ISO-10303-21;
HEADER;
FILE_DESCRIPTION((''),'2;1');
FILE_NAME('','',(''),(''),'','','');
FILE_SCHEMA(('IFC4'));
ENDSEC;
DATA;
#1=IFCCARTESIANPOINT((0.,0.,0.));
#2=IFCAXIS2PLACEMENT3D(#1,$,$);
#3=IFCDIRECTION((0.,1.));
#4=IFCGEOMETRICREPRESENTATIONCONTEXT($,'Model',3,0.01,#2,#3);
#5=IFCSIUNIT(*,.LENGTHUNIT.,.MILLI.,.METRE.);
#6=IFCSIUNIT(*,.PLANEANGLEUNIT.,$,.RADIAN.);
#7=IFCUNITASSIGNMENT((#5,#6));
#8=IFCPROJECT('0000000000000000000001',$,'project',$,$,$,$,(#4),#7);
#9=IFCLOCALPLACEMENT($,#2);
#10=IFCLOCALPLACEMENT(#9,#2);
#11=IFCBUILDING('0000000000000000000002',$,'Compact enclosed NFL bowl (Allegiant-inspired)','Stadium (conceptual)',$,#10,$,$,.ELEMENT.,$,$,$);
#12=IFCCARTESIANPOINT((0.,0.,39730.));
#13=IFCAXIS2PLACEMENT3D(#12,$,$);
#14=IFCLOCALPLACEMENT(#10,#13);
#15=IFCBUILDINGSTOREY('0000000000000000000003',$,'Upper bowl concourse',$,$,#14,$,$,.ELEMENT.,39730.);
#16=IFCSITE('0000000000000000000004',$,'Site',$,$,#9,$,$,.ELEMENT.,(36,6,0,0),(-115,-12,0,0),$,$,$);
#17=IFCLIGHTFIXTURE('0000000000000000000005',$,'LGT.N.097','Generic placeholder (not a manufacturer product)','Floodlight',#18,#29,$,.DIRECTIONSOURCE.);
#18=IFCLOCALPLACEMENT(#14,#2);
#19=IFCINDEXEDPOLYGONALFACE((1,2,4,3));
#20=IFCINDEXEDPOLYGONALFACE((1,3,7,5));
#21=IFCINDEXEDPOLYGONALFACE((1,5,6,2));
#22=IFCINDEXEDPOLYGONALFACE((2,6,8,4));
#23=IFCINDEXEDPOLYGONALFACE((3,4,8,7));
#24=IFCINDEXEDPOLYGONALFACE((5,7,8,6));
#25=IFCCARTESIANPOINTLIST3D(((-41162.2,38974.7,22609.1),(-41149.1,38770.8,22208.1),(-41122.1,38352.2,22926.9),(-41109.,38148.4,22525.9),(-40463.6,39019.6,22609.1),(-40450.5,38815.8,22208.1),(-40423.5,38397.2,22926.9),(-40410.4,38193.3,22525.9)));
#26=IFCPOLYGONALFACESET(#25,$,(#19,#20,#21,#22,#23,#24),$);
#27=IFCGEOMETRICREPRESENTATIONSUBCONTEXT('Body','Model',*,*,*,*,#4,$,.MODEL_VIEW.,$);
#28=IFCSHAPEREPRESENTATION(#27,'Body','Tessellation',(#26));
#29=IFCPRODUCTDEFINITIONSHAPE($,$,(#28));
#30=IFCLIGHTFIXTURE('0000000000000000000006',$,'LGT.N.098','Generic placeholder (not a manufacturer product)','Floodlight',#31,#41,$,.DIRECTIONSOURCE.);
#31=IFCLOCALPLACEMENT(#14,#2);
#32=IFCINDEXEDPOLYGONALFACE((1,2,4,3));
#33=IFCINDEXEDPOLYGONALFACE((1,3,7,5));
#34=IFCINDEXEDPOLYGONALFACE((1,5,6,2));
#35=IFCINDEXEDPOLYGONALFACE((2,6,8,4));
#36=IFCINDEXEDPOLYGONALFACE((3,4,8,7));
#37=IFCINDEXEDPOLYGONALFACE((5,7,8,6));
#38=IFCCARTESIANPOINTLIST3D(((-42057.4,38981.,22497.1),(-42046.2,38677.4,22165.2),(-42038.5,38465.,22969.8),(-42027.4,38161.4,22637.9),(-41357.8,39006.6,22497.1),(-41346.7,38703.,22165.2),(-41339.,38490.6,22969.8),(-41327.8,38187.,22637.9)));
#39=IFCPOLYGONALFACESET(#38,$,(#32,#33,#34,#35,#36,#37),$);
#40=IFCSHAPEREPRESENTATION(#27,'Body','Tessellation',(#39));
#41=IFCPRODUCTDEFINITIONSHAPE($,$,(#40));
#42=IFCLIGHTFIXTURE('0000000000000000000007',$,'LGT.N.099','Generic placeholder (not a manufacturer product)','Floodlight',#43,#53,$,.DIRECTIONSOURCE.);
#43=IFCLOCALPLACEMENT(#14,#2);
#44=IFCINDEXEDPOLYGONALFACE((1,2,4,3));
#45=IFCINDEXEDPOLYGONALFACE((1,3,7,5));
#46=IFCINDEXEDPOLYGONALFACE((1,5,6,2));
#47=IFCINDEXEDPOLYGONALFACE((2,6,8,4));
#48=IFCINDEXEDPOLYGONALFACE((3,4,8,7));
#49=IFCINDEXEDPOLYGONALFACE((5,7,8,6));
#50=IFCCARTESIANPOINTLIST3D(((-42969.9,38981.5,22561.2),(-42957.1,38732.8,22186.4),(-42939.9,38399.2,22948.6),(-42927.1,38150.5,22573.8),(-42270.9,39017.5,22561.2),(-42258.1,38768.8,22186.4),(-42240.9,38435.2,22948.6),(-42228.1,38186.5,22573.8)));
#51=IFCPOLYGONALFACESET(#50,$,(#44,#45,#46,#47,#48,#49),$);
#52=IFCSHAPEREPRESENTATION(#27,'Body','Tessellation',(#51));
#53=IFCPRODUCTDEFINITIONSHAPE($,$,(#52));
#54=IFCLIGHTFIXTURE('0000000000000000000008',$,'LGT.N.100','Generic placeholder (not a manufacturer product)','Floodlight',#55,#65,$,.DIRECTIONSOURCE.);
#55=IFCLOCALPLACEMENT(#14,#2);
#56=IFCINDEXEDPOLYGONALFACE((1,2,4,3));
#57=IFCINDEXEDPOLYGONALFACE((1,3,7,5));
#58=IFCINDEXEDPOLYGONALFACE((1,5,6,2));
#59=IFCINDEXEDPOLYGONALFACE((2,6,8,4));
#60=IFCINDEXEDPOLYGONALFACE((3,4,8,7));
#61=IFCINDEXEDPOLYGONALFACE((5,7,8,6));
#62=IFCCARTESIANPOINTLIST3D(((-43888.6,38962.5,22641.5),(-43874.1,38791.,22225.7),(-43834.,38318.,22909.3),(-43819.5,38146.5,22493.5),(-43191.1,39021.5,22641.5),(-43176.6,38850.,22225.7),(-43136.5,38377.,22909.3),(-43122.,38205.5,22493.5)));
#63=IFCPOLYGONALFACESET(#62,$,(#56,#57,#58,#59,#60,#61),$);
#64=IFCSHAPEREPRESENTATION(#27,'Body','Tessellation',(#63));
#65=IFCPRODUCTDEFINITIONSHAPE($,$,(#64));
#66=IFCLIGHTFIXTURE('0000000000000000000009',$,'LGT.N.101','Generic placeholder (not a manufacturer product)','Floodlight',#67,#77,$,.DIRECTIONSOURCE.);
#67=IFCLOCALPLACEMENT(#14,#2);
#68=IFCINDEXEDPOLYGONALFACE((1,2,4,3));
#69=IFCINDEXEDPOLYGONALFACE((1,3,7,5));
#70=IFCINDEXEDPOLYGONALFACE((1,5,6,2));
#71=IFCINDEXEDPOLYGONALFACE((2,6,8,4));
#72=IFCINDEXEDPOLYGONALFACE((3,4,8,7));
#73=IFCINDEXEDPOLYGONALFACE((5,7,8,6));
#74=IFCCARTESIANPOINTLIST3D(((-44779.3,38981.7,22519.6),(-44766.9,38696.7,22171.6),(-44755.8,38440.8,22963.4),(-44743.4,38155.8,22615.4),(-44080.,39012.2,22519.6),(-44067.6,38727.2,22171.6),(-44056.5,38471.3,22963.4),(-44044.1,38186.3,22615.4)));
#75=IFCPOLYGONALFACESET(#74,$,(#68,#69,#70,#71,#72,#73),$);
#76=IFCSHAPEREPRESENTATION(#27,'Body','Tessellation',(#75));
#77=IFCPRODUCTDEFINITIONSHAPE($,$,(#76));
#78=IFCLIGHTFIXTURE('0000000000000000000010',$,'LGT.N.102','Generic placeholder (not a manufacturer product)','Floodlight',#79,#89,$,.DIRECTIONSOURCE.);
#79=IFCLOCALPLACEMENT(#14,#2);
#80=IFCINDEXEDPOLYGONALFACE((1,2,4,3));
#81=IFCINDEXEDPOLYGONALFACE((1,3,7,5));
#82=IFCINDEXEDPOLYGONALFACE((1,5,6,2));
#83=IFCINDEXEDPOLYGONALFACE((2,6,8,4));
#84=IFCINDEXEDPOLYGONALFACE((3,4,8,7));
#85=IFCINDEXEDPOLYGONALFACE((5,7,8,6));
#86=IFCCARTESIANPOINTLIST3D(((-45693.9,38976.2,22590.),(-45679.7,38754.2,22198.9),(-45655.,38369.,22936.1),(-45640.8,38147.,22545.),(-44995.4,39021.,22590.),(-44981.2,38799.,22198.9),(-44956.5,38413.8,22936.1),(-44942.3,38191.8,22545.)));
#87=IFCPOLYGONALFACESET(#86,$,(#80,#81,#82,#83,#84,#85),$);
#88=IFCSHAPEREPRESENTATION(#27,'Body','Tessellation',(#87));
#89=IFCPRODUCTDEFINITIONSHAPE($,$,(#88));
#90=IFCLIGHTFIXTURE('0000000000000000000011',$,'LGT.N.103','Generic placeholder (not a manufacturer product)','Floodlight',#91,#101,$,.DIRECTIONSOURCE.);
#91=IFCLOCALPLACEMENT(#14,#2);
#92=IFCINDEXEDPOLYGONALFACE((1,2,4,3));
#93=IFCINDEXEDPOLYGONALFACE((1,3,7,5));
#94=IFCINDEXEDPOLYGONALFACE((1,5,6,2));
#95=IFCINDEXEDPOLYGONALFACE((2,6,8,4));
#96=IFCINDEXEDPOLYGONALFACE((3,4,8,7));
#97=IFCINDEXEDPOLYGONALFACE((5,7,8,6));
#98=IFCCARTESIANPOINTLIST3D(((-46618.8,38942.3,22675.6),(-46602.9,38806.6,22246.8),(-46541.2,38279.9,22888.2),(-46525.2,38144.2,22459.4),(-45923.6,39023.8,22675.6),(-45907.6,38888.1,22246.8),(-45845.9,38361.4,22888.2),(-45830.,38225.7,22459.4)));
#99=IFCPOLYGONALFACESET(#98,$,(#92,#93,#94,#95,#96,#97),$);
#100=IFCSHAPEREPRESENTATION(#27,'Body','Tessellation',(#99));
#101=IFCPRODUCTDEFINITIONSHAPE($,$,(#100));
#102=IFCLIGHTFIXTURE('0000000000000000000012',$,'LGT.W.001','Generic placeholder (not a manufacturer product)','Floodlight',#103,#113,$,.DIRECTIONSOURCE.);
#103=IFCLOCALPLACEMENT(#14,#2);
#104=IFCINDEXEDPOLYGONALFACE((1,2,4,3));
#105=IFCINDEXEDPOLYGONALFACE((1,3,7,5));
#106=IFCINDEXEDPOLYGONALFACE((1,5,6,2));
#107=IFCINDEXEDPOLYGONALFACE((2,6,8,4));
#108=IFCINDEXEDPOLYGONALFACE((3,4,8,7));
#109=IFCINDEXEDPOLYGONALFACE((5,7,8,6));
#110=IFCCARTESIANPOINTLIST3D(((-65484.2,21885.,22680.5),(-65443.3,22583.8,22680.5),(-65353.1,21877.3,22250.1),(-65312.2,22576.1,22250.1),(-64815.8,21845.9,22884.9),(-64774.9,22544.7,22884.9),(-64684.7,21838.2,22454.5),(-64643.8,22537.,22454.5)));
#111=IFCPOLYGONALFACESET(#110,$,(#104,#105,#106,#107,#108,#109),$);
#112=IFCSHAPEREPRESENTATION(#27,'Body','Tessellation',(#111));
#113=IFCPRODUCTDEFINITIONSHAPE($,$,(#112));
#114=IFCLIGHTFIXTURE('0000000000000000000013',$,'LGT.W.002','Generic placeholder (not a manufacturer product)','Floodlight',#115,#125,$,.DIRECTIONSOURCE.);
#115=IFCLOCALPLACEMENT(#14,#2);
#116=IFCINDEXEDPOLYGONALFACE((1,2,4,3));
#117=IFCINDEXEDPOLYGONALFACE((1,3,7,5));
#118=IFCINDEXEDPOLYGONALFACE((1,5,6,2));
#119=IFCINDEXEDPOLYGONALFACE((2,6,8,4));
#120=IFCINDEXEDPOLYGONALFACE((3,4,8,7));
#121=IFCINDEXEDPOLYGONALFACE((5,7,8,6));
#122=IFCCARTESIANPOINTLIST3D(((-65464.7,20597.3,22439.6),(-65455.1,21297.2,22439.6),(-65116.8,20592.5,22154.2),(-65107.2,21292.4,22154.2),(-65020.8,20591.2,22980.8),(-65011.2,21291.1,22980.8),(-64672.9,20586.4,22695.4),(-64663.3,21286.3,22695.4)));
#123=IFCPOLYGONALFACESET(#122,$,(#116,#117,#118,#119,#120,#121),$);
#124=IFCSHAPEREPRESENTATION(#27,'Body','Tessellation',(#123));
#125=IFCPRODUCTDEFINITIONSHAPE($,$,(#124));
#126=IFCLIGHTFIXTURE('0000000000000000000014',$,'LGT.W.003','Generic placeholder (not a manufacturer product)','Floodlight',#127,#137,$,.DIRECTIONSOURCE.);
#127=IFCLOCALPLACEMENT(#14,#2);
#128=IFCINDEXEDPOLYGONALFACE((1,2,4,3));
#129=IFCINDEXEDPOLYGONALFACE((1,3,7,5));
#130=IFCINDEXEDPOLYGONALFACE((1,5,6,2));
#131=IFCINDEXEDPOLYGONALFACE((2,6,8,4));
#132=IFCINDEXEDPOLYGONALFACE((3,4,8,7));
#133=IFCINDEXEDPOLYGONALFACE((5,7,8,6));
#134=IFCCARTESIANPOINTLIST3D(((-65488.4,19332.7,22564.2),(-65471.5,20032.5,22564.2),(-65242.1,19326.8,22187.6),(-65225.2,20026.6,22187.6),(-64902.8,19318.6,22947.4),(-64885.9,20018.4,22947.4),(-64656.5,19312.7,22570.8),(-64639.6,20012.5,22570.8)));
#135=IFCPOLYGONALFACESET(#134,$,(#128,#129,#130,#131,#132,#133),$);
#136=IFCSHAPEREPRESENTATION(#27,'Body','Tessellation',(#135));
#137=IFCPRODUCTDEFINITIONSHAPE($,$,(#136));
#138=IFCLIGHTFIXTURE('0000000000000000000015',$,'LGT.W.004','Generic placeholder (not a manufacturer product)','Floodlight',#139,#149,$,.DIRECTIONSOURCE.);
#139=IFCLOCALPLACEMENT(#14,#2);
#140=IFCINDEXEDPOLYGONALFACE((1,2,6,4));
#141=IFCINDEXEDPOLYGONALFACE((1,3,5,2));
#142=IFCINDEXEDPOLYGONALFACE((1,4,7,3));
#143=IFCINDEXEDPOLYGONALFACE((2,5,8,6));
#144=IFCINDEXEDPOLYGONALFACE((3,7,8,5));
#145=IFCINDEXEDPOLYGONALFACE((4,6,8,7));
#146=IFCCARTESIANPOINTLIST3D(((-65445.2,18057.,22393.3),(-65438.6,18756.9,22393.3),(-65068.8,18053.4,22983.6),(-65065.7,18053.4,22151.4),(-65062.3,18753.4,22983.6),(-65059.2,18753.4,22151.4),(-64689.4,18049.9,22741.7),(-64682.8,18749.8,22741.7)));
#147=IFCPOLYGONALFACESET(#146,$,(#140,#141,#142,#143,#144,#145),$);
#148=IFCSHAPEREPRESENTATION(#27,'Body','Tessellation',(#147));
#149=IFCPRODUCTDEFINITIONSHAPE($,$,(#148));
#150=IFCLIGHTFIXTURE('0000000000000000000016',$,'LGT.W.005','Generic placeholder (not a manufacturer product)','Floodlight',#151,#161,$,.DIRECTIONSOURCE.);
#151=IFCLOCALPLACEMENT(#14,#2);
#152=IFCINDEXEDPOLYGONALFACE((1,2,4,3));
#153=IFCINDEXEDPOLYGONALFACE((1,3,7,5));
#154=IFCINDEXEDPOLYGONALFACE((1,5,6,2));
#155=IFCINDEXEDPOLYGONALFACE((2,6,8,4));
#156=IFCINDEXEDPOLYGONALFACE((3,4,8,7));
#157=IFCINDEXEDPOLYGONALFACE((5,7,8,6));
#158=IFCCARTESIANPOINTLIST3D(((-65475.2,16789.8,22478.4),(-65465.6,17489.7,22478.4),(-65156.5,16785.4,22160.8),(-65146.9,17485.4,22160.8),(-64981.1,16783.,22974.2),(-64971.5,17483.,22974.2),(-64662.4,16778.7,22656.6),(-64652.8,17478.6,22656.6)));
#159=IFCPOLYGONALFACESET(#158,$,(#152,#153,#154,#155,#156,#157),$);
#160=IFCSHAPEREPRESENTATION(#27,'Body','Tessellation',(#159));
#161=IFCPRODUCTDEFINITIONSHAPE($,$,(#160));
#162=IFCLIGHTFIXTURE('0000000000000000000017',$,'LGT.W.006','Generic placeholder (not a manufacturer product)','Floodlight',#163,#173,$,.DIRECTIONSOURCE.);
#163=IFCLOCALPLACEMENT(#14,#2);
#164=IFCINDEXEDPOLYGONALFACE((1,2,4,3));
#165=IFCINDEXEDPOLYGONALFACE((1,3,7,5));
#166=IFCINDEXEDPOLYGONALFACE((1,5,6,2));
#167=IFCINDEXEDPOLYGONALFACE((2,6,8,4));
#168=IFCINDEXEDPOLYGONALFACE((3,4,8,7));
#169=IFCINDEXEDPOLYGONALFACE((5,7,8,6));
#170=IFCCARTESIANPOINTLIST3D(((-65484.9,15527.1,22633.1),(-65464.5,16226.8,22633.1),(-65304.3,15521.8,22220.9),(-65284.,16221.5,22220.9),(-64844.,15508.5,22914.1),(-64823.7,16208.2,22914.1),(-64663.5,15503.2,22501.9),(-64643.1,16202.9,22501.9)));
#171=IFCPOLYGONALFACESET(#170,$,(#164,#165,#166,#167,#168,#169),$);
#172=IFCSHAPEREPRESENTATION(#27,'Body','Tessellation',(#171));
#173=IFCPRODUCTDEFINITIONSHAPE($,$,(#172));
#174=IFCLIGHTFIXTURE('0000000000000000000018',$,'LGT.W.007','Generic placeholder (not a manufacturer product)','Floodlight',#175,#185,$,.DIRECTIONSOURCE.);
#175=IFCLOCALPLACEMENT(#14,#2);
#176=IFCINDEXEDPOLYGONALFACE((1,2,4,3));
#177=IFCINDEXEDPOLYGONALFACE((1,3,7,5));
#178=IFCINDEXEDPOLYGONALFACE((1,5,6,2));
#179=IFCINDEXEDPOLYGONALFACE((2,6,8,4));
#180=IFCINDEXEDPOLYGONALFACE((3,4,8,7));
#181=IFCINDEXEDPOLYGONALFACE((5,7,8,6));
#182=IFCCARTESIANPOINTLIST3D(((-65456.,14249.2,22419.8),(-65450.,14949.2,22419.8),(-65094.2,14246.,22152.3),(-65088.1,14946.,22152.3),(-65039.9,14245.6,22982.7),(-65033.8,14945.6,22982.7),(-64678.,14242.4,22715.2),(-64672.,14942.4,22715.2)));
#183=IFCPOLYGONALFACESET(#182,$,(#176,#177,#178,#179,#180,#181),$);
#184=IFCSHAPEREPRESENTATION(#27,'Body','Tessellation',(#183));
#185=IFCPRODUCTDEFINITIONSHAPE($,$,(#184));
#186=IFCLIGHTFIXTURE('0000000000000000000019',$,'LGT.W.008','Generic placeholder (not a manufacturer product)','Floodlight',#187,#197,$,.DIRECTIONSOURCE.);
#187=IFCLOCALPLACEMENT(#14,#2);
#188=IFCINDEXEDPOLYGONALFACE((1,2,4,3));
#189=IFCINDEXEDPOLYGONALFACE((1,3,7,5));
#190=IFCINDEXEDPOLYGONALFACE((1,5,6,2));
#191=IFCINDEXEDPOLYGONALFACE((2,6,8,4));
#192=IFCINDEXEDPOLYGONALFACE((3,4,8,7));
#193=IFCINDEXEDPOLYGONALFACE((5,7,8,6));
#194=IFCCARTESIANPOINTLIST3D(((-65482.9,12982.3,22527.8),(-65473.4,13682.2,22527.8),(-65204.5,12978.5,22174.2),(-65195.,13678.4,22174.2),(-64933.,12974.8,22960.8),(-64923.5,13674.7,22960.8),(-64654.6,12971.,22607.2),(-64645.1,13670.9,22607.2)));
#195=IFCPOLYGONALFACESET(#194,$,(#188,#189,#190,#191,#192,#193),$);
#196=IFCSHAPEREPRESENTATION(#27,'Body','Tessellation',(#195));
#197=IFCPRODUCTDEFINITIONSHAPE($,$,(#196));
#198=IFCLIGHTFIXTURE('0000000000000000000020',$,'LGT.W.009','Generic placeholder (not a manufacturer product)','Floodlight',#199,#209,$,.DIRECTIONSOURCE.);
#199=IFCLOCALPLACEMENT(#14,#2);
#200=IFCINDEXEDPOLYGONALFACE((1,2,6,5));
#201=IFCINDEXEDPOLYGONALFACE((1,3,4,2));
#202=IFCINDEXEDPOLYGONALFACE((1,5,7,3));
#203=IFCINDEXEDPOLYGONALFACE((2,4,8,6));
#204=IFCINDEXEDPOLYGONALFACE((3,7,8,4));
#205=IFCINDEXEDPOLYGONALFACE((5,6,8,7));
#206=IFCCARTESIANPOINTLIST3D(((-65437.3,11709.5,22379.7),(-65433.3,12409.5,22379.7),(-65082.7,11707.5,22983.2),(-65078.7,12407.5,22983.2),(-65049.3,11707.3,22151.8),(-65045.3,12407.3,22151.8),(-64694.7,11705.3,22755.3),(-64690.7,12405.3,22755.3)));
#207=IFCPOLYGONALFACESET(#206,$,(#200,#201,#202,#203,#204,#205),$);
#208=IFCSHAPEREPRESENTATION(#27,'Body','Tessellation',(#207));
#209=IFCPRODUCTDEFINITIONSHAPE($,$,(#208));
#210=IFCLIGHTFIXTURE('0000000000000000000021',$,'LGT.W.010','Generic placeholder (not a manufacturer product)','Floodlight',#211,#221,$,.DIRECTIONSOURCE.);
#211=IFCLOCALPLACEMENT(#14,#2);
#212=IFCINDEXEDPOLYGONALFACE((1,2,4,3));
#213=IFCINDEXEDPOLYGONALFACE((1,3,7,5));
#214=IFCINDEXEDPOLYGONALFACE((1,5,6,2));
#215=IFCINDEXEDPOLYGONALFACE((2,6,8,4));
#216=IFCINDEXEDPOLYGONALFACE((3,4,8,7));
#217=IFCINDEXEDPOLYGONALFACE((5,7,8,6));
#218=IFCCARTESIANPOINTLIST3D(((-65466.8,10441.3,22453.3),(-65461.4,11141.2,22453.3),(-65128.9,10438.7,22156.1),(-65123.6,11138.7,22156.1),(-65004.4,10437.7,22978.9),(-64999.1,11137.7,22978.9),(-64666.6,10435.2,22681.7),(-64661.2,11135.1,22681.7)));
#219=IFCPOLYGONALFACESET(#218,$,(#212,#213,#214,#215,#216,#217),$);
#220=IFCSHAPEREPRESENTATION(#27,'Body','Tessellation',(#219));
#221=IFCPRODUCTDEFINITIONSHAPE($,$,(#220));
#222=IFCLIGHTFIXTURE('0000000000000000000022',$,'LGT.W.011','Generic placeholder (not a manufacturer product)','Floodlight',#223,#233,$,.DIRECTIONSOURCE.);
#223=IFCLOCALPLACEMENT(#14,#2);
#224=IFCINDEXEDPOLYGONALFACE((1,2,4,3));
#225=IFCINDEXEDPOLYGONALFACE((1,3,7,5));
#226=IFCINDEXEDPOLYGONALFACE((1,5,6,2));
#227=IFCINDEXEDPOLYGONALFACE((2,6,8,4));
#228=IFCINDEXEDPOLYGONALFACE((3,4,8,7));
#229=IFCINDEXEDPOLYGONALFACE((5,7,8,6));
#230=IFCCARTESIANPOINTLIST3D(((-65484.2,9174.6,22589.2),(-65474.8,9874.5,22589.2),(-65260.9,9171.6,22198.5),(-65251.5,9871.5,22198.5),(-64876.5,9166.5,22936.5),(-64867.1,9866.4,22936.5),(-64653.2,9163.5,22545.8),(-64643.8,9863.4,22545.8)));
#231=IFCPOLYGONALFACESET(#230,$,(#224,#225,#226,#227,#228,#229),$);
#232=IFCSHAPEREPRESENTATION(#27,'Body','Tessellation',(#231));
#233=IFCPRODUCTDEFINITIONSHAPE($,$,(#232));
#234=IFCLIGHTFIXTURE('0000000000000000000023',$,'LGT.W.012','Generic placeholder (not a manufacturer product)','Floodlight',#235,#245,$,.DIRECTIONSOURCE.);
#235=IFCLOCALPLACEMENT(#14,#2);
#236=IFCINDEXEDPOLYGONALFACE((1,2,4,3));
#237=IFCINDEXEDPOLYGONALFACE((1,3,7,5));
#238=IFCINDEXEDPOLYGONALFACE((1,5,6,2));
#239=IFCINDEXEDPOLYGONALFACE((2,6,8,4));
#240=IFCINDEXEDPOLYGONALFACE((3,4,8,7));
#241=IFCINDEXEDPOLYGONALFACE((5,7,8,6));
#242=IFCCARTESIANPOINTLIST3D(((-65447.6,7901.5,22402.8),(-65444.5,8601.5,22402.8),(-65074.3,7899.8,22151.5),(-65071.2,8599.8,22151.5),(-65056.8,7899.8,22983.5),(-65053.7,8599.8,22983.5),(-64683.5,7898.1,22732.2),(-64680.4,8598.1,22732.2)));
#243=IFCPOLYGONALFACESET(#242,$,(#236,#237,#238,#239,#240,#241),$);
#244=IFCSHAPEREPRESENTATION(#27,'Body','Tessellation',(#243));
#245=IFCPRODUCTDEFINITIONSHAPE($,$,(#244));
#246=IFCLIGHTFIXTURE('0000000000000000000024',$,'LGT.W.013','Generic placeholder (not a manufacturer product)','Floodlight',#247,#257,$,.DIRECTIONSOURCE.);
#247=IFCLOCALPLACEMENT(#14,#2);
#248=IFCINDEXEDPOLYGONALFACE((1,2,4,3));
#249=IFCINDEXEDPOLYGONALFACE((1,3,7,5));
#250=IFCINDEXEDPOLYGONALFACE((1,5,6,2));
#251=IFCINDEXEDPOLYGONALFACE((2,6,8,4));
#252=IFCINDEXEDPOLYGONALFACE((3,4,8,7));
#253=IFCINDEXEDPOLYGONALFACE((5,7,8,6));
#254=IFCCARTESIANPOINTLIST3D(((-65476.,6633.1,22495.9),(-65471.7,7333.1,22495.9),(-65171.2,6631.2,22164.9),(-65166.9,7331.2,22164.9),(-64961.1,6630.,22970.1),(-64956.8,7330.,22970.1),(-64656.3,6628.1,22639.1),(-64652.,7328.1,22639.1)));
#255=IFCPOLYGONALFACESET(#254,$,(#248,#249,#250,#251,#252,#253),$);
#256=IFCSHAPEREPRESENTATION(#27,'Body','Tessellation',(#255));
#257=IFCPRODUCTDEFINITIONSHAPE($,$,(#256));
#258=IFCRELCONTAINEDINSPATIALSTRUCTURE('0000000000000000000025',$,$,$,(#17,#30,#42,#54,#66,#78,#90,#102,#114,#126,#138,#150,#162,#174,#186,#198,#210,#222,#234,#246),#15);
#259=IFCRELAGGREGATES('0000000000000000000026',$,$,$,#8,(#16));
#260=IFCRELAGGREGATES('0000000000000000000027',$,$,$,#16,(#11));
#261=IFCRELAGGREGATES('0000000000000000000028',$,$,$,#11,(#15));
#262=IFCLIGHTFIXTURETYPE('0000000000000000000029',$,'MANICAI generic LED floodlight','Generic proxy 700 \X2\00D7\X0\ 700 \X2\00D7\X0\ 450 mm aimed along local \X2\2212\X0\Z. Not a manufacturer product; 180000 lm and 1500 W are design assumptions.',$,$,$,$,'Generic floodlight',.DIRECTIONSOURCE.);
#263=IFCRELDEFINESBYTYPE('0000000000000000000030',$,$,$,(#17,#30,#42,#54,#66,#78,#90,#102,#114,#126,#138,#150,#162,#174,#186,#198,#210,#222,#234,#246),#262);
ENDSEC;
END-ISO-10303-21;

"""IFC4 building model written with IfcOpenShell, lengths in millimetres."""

from ifc_helpers import new_model, si_unit, direction, frame, origin, place, context, subcontext, project, spatial, rectangle, extrude, source, transform, mapped, type_object, type_shapes, element, save


model = new_model("IFC4")

# Units and contexts
model_context = context("Model", 3, precision=0.01, world=origin(), true_north=direction((0.0, 1.0)))
body_context = subcontext(model_context, "Body", "Model", "MODEL_VIEW")
ifc_project = project(units=[si_unit("LENGTHUNIT", "METRE", prefix="MILLI"), si_unit("PLANEANGLEUNIT", "RADIAN")], contexts=[model_context])

# Site, building, storey
site_placement = place(None, origin())
site = spatial("IfcSite", under=ifc_project, at=site_placement, Name="Site", CompositionType="ELEMENT", RefLatitude=(36, 6, 0, 0), RefLongitude=(-115, -12, 0, 0))
building_placement = place(site_placement, origin())
building = spatial("IfcBuilding", under=site, at=building_placement, Name="Compact enclosed NFL bowl (Allegiant-inspired)", Description="Stadium (conceptual)", CompositionType="ELEMENT")
storey_placement = place(building_placement, frame((0.0, 0.0, 39730.0)))
storey = spatial("IfcBuildingStorey", under=building, at=storey_placement, Name="Upper bowl concourse", CompositionType="ELEMENT", Elevation=39730.0)

# Light fixtures
light_fixture_type = type_object("IfcLightFixtureType", Name="MANICAI generic LED floodlight", Description="Generic proxy 700 × 700 × 450 mm aimed along local −Z. Not a manufacturer product; 180000 lm and 1500 W are design assumptions.", ElementType="Generic floodlight", PredefinedType="DIRECTIONSOURCE")
shared_shape = source(origin(), body_context, "Body", "SweptSolid", [
    extrude(rectangle(XDim=700.0, YDim=700.0), frame((0.0, 0.0, -225.0)), (0.0, 0.0, 1.0), 450.0),
])
type_shapes(light_fixture_type, [shared_shape])
for number, where, z_axis, x_axis, name in (
    (1, (-40786.3, 38584.0, 22567.5), (-0.029168, 0.452997, 0.891035), (-0.997933, -0.064256, 0.0), "LGT.N.097"),
    (2, (-41692.6, 38584.0, 22567.5), (-0.024683, 0.674769, 0.737616), (-0.999332, -0.036555, 0.0), "LGT.N.098"),
    (3, (-42599.0, 38584.0, 22567.5), (-0.028476, 0.552721, 0.83288), (-0.998675, -0.051452, 0.0), "LGT.N.099"),
    (4, (-43505.3, 38584.0, 22567.5), (-0.032263, 0.381097, 0.923972), (-0.996436, -0.084356, 0.0), "LGT.N.100"),
    (5, (-44411.7, 38584.0, 22567.5), (-0.027568, 0.63331, 0.773407), (-0.999054, -0.043489, 0.0), "LGT.N.101"),
    (6, (-45318.1, 38584.0, 22567.5), (-0.031615, 0.493437, 0.869206), (-0.997954, -0.06394, 0.0), "LGT.N.102"),
    (7, (-46224.4, 38584.0, 22567.5), (-0.035348, 0.301573, 0.952788), (-0.993201, -0.116416, 0.0), "LGT.N.103"),
    (8, (-65064.0, 22211.0, 22567.5), (-0.291374, 0.01705, 0.956457), (-0.058417, -0.998292, 0.0), "LGT.W.001"),
    (9, (-65064.0, 20941.8, 22567.5), (-0.773104, 0.010659, 0.634189), (-0.013786, -0.999905, 0.0), "LGT.W.002"),
    (10, (-65064.0, 19672.6, 22567.5), (-0.547239, 0.013214, 0.836872), (-0.024139, -0.999709, 0.0), "LGT.W.003"),
    (11, (-65064.0, 18403.4, 22567.5), (-0.843152, 0.007941, 0.537616), (-0.009418, -0.999956, 0.0), "LGT.W.004"),
    (12, (-65064.0, 17134.2, 22567.5), (-0.708196, 0.009708, 0.705949), (-0.013707, -0.999906, 0.0), "LGT.W.005"),
    (13, (-65064.0, 15865.0, 22567.5), (-0.401213, 0.011663, 0.91591), (-0.029056, -0.999578, 0.0), "LGT.W.006"),
    (14, (-65064.0, 14595.8, 22567.5), (-0.804054, 0.006965, 0.594515), (-0.008661, -0.999962, 0.0), "LGT.W.007"),
    (15, (-65064.0, 13326.6, 22567.5), (-0.61858, 0.008404, 0.785677), (-0.013584, -0.999908, 0.0), "LGT.W.008"),
    (16, (-65064.0, 12057.4, 22567.5), (-0.862149, 0.004903, 0.506632), (-0.005687, -0.999984, 0.0), "LGT.W.009"),
    (17, (-65064.0, 10788.2, 22567.5), (-0.750767, 0.005719, 0.660542), (-0.007618, -0.999971, 0.0), "LGT.W.010"),
    (18, (-65064.0, 9519.0, 22567.5), (-0.496148, 0.006633, 0.868213), (-0.013368, -0.999911, 0.0), "LGT.W.011"),
    (19, (-65064.0, 8249.8, 22567.5), (-0.829608, 0.003697, 0.558334), (-0.004456, -0.99999, 0.0), "LGT.W.012"),
    (20, (-65064.0, 6980.6, 22567.5), (-0.677342, 0.004122, 0.735657), (-0.006085, -0.999981, 0.0), "LGT.W.013"),
):
    element("IfcLightFixture", number, at=place(storey_placement, frame(where, z_axis=z_axis, x_axis=x_axis)), inside=storey, type_object=light_fixture_type, Name=name, Description="Generic placeholder (not a manufacturer product)", ObjectType="Floodlight", PredefinedType="DIRECTIONSOURCE", context=body_context, shape_type="MappedRepresentation", body=[
        mapped(shared_shape, transform((0.0, 0.0, 0.0))),
    ])

save(model, "model.ifc")
